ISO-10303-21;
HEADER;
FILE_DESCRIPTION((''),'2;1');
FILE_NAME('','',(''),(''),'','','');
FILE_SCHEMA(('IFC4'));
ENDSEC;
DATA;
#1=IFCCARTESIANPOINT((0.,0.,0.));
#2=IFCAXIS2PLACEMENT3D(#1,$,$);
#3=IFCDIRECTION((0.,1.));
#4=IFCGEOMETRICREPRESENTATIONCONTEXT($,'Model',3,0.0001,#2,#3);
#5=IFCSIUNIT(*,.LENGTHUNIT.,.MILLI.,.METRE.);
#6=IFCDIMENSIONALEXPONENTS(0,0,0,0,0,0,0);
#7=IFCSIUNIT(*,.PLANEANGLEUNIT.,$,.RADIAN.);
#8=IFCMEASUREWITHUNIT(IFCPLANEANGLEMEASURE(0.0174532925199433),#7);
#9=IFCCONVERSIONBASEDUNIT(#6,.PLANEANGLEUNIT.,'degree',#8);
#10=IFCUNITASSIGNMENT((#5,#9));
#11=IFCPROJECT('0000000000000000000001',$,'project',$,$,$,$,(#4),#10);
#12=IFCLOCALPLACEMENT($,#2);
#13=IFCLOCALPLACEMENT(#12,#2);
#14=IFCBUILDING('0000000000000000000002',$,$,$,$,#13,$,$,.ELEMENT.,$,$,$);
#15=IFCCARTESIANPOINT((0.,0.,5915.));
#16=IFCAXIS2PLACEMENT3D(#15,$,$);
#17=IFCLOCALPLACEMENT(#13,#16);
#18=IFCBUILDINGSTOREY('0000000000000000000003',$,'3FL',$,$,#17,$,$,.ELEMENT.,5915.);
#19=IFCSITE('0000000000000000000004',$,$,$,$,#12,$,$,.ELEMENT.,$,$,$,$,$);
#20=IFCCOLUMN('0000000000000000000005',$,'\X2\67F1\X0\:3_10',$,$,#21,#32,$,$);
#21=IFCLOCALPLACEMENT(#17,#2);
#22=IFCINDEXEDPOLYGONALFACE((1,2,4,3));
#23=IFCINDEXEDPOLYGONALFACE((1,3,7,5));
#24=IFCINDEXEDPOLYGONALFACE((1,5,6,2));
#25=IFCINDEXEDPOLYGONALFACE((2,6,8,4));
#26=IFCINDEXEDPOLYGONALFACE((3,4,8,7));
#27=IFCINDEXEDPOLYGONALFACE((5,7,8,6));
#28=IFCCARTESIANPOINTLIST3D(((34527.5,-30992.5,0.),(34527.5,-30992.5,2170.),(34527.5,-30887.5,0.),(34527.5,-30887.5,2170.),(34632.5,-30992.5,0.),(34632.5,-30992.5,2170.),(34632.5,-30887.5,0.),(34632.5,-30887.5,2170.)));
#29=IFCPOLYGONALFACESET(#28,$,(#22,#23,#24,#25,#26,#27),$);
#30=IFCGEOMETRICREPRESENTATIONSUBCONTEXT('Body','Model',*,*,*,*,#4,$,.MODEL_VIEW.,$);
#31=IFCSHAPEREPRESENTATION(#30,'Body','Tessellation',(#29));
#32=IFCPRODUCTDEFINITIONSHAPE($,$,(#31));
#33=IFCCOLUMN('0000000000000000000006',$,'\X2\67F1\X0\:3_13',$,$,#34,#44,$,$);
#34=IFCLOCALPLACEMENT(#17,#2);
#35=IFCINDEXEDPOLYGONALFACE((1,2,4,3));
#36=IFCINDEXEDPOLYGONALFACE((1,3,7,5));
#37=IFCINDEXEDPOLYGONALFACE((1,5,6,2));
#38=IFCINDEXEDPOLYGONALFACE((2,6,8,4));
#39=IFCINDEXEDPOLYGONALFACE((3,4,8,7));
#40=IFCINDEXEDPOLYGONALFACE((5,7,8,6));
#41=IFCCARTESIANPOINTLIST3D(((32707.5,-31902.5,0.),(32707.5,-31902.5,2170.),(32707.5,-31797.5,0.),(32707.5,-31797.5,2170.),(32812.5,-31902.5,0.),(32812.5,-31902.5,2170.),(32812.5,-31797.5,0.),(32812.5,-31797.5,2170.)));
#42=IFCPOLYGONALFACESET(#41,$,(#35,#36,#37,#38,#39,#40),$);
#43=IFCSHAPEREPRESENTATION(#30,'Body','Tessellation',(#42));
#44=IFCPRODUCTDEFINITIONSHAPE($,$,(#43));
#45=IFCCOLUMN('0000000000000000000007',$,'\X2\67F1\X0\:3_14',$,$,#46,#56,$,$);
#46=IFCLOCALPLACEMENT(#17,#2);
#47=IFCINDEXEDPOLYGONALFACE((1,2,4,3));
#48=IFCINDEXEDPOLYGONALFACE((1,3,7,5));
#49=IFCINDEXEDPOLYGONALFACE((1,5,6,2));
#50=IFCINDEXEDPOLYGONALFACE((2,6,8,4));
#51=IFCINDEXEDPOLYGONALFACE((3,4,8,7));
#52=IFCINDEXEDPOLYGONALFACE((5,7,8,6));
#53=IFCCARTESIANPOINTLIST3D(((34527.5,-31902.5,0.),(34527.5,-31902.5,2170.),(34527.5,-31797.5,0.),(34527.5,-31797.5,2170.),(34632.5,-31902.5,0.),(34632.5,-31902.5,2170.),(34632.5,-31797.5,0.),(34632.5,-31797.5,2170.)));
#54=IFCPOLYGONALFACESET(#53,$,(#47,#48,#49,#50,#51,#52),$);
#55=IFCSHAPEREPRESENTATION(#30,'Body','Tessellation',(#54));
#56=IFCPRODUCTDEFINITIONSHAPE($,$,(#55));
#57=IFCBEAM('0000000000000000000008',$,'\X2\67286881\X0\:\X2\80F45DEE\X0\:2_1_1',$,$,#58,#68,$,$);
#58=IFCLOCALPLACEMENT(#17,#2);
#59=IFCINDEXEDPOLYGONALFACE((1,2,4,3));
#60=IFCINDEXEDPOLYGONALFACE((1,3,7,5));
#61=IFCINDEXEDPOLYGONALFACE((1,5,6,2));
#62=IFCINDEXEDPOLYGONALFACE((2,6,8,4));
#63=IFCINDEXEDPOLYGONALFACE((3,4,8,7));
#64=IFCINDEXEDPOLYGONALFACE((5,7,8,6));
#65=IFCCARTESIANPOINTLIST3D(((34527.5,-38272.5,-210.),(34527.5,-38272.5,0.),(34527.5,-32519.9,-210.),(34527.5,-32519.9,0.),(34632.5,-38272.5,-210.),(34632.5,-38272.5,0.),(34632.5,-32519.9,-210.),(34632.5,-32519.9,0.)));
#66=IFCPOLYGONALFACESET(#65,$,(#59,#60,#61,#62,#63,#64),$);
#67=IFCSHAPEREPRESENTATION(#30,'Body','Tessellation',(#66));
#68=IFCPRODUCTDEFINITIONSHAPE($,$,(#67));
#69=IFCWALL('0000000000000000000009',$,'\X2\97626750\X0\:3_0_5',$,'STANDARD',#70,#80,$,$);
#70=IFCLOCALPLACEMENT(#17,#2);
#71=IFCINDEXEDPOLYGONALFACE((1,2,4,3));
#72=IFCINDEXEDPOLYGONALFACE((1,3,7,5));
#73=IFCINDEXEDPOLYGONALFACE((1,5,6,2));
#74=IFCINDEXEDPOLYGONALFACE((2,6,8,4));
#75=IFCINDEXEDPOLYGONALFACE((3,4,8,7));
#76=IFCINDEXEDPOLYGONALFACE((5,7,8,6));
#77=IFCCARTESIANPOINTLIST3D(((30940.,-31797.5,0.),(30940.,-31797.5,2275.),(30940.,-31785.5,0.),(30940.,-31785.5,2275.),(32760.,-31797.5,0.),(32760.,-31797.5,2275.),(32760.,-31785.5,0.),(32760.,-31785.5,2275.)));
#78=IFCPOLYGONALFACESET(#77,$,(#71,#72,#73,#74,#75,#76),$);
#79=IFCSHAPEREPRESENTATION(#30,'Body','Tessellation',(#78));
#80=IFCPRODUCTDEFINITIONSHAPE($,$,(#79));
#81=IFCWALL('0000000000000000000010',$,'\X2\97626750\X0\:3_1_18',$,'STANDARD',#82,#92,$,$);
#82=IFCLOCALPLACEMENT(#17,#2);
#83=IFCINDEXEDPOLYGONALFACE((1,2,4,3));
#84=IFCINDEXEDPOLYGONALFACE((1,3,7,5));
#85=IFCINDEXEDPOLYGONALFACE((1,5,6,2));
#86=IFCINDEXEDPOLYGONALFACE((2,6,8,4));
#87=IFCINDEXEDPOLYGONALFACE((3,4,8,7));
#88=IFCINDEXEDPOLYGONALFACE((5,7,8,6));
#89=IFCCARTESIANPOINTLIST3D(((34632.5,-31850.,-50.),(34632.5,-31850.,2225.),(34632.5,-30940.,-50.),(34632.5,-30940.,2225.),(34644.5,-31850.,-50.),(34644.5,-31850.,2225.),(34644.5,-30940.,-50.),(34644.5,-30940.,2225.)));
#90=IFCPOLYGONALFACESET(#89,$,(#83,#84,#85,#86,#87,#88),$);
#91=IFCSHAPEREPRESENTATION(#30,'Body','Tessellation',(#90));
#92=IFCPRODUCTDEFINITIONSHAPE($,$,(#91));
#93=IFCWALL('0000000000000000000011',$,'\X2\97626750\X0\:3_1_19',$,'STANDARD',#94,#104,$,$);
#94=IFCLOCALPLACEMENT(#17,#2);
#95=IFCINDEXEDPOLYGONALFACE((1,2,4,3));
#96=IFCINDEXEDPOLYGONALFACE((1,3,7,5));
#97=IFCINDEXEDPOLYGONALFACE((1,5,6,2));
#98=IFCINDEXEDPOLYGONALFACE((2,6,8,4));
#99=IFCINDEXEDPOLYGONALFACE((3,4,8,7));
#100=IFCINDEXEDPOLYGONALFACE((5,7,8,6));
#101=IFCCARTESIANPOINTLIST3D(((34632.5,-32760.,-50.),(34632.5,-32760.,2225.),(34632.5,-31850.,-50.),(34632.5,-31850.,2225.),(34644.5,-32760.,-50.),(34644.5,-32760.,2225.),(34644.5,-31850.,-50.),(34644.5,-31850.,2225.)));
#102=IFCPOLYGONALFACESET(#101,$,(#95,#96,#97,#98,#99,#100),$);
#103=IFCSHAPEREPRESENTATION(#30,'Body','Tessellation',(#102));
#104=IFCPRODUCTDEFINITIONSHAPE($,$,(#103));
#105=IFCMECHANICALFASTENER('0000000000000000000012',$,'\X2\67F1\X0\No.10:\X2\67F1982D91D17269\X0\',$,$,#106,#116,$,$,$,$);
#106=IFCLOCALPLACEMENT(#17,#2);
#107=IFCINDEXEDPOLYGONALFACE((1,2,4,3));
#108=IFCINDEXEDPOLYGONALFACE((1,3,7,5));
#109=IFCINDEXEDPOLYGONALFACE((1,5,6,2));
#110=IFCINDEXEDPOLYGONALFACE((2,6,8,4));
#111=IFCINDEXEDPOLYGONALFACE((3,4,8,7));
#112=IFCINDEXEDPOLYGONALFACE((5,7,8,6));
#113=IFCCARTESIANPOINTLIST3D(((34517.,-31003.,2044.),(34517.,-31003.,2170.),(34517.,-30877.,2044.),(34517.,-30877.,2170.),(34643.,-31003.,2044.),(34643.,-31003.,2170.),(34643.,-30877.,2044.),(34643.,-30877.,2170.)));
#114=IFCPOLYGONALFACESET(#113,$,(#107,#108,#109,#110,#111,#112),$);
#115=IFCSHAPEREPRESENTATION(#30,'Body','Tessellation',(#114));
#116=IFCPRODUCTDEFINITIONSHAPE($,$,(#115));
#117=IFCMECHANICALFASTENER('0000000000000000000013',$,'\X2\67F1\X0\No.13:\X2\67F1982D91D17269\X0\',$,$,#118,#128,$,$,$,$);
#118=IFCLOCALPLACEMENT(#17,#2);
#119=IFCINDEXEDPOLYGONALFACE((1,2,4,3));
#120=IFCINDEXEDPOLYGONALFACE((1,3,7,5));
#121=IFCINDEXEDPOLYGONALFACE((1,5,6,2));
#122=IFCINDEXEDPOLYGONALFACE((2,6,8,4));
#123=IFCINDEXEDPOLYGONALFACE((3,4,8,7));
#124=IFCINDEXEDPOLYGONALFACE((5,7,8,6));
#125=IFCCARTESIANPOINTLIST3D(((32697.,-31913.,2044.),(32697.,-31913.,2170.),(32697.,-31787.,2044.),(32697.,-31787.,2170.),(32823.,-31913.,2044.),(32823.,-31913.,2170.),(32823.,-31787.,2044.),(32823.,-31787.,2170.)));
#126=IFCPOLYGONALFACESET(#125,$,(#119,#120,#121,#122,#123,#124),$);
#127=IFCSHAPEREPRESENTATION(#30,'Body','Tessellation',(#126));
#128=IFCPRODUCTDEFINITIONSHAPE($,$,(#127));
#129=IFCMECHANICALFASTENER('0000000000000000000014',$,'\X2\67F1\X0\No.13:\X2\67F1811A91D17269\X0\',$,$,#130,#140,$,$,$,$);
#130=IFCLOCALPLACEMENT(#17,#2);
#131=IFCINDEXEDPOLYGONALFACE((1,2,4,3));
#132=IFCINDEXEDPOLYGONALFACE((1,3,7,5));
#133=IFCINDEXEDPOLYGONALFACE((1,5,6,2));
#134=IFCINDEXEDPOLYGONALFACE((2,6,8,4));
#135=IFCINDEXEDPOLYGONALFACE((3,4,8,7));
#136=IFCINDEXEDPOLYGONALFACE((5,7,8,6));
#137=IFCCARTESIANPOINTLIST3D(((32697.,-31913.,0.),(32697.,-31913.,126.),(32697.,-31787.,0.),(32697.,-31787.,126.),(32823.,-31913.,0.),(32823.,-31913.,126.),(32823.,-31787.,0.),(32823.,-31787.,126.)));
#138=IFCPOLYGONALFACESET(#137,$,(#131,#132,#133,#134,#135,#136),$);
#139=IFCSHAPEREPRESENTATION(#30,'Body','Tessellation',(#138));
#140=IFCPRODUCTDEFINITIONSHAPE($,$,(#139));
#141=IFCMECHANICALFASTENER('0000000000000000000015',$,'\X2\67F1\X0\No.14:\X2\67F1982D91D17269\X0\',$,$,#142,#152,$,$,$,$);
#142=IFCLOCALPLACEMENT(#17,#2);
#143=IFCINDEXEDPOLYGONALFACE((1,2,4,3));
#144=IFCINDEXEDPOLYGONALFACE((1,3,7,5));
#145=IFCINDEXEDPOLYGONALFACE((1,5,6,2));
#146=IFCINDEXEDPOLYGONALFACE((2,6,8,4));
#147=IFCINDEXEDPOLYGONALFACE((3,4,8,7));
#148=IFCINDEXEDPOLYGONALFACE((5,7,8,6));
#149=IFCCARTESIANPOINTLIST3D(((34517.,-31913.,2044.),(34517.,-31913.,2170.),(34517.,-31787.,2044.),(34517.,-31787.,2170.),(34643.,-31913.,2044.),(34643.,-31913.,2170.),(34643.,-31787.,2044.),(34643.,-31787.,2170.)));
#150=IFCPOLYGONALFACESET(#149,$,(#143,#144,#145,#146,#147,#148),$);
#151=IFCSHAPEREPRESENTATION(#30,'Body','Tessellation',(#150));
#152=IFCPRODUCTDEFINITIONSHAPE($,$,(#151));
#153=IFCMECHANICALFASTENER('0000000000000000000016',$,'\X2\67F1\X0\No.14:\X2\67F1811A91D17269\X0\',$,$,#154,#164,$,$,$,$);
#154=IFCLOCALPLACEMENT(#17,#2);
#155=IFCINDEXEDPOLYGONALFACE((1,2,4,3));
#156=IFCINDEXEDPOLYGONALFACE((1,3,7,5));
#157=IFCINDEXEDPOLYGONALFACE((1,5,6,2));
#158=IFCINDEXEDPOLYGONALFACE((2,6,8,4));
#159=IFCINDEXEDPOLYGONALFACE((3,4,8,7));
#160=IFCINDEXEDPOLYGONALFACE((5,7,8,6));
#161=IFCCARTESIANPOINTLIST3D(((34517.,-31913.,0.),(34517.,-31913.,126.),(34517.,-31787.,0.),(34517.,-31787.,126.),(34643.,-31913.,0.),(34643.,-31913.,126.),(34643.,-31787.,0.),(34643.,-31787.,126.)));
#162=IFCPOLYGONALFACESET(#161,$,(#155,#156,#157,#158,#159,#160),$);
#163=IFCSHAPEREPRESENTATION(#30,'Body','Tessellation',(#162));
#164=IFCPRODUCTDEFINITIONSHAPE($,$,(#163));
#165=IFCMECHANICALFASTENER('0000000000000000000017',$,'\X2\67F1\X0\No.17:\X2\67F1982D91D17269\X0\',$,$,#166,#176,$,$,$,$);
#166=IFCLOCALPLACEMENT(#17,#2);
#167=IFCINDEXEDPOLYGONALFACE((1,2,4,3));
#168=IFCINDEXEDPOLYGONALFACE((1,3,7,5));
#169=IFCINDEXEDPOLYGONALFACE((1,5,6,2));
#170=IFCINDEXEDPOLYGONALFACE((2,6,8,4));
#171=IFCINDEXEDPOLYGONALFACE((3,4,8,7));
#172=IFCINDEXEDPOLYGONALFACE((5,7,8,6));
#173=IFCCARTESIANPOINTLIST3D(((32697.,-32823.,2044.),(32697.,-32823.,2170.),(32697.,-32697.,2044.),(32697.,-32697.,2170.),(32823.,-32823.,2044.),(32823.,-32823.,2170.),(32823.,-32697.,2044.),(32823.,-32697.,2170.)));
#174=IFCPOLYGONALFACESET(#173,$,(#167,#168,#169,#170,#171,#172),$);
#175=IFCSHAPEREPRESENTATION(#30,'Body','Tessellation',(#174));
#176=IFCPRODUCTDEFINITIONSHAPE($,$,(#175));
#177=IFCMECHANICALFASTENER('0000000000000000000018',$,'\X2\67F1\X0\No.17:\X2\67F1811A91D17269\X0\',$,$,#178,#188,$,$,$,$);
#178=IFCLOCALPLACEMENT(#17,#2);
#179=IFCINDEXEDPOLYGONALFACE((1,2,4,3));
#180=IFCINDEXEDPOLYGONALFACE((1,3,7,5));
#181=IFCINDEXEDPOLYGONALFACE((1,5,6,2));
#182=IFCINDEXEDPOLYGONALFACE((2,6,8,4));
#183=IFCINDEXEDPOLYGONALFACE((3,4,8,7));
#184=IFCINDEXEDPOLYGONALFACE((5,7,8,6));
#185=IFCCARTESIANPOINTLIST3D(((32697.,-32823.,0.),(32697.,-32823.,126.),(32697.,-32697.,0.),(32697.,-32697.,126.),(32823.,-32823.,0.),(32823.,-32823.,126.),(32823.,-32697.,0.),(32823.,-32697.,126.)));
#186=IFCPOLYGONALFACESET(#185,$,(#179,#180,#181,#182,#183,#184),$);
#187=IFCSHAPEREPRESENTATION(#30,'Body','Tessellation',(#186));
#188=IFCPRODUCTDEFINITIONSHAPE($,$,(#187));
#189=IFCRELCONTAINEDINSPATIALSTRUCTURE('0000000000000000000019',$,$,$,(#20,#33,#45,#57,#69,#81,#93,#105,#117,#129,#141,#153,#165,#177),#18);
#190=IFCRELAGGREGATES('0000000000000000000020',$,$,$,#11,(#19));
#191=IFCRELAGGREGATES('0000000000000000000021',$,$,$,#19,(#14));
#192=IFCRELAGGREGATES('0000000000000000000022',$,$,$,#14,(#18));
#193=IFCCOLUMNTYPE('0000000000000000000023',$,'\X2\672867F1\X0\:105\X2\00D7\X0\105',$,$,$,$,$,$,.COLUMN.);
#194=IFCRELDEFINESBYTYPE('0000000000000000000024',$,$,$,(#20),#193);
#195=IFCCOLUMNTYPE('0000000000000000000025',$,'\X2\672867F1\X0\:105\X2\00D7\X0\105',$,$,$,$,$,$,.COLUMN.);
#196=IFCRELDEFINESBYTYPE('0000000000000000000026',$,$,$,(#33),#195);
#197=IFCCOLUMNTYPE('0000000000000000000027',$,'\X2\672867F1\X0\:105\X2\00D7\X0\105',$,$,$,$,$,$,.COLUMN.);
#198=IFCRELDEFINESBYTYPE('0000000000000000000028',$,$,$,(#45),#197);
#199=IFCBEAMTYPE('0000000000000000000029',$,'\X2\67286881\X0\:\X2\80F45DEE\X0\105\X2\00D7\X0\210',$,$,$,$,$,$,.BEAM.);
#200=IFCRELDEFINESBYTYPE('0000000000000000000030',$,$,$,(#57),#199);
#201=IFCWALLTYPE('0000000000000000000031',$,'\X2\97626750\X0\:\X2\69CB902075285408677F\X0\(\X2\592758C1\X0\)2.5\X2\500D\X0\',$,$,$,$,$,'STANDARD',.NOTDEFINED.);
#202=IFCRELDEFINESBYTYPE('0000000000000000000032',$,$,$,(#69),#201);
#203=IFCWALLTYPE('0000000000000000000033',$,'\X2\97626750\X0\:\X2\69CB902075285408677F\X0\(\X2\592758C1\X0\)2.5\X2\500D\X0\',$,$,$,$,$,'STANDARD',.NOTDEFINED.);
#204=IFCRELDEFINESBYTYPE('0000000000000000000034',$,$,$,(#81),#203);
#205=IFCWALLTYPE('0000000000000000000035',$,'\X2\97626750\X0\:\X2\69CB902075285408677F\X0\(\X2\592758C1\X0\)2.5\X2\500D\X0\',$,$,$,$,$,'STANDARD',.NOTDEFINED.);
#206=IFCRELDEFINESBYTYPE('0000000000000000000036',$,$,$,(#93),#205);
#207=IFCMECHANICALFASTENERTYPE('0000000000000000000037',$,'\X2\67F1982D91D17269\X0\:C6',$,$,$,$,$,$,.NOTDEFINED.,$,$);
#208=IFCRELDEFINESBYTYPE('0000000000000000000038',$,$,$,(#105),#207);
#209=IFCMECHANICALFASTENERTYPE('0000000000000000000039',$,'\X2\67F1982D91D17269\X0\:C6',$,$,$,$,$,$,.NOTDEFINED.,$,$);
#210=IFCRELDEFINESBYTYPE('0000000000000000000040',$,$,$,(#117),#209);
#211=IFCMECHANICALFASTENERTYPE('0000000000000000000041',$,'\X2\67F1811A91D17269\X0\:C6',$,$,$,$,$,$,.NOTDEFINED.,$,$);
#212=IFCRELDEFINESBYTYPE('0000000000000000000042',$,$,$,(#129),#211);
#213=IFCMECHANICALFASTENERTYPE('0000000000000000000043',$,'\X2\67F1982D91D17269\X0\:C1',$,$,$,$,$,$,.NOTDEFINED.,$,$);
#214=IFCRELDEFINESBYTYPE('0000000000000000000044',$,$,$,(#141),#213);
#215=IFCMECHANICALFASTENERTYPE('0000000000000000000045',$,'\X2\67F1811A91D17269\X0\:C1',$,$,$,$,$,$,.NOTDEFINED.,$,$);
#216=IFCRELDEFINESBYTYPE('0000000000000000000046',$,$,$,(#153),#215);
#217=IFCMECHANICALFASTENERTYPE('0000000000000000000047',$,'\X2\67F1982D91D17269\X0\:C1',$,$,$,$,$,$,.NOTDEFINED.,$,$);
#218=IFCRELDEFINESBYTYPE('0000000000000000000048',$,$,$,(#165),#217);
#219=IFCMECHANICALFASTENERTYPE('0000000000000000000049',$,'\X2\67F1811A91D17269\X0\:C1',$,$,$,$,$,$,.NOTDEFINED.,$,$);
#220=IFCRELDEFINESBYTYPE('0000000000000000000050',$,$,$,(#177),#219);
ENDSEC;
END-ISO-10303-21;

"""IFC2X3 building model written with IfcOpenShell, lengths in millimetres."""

from ifc_helpers import new_model, entity, si_unit, converted_unit, direction, frame, origin, origin_with_axes, origin_2d, place, context, subcontext, project, spatial, polyline, rectangle, outline, extrude, type_object, element, save


model = new_model("IFC2X3")

# Units and contexts
model_context = context("Model", 3, precision=0.0001, world=origin(), true_north=direction((0.0, 1.0)))
body_context = subcontext(model_context, "Body", "Model", "MODEL_VIEW")
ifc_project = project(units=[si_unit("LENGTHUNIT", "METRE", prefix="MILLI"), converted_unit("PLANEANGLEUNIT", "degree", entity("IfcPlaneAngleMeasure", 0.0174532925199433), si_unit("PLANEANGLEUNIT", "RADIAN"), dimensions=[0, 0, 0, 0, 0, 0, 0])], contexts=[model_context])

# Site, building, storey
site_placement = place(None, origin())
site = spatial("IfcSite", under=ifc_project, at=site_placement, CompositionType="ELEMENT")
building_placement = place(site_placement, origin())
building = spatial("IfcBuilding", under=site, at=building_placement, CompositionType="ELEMENT")
storey_placement = place(building_placement, frame((0.0, 0.0, 5915.0)))
storey = spatial("IfcBuildingStorey", under=building, at=storey_placement, Name="3FL", CompositionType="ELEMENT", Elevation=5915.0)

# Columns
column_type_1 = type_object("IfcColumnType", Name="木柱:105×105", PredefinedType="COLUMN")
column_1_placement = place(storey_placement, frame((34580.0, -30940.0, 0.0)))
element("IfcColumn", 1, at=column_1_placement, inside=storey, type_object=column_type_1, Name="柱:3_10", context=body_context, shape_type="SweptSolid", body=[
    extrude(rectangle(XDim=105.0, YDim=105.0, at=origin_2d()), origin_with_axes(), (0.0, 0.0, 1.0), 2170.0),
])
column_type_2 = type_object("IfcColumnType", Name="木柱:105×105", PredefinedType="COLUMN")
column_2_placement = place(storey_placement, frame((32760.0, -31850.0, 0.0)))
element("IfcColumn", 2, at=column_2_placement, inside=storey, type_object=column_type_2, Name="柱:3_13", context=body_context, shape_type="SweptSolid", body=[
    extrude(rectangle(XDim=105.0, YDim=105.0, at=origin_2d()), origin_with_axes(), (0.0, 0.0, 1.0), 2170.0),
])
column_type_3 = type_object("IfcColumnType", Name="木柱:105×105", PredefinedType="COLUMN")
column_3_placement = place(storey_placement, frame((34580.0, -31850.0, 0.0)))
element("IfcColumn", 3, at=column_3_placement, inside=storey, type_object=column_type_3, Name="柱:3_14", context=body_context, shape_type="SweptSolid", body=[
    extrude(rectangle(XDim=105.0, YDim=105.0, at=origin_2d()), origin_with_axes(), (0.0, 0.0, 1.0), 2170.0),
])

# Beam
beam_type = type_object("IfcBeamType", Name="木梁:胴差105×210", PredefinedType="BEAM")
beam_placement = place(storey_placement, frame((34580.0, -32519.9, -105.0), z_axis=(0.0, -1.0, 0.0), x_axis=(1.0, 0.0, 0.0)))
element("IfcBeam", 4, at=beam_placement, inside=storey, type_object=beam_type, Name="木梁:胴差:2_1_1", context=body_context, shape_type="SweptSolid", body=[
    extrude(rectangle(XDim=105.0, YDim=210.0, at=origin_2d()), origin_with_axes(), (0.0, 0.0, 1.0), 5752.6),
])

# Walls
wall_type_1 = type_object("IfcWallType", Name="面材:構造用合板(大壁)2.5倍", ElementType="STANDARD", PredefinedType="NOTDEFINED")
wall_1_placement = place(storey_placement, frame((31850.0, -31785.5, 0.0), z_axis=(0.0, -1.0, 0.0), x_axis=(1.0, 0.0, 0.0)))
element("IfcWall", 5, at=wall_1_placement, inside=storey, type_object=wall_type_1, Name="面材:3_0_5", ObjectType="STANDARD", context=body_context, shape_type="SweptSolid", body=[
    extrude(outline(polyline([(910.0, 0.0, 0.0), (-910.0, 0.0, 0.0), (-910.0, 2275.0, 0.0), (910.0, 2275.0, 0.0), (910.0, 0.0, 0.0)])), origin_with_axes(), (0.0, 0.0, 1.0), 12.0),
])
wall_type_2 = type_object("IfcWallType", Name="面材:構造用合板(大壁)2.5倍", ElementType="STANDARD", PredefinedType="NOTDEFINED")
wall_2_placement = place(storey_placement, frame((34644.5, -31395.0, -50.0), z_axis=(-1.0, 0.0, 0.0), x_axis=(0.0, -1.0, 0.0)))
element("IfcWall", 6, at=wall_2_placement, inside=storey, type_object=wall_type_2, Name="面材:3_1_18", ObjectType="STANDARD", context=body_context, shape_type="SweptSolid", body=[
    extrude(outline(polyline([(455.0, 0.0, 0.0), (-455.0, 0.0, 0.0), (-455.0, 2275.0, 0.0), (455.0, 2275.0, 0.0), (455.0, 0.0, 0.0)])), origin_with_axes(), (0.0, 0.0, 1.0), 12.0),
])
wall_type_3 = type_object("IfcWallType", Name="面材:構造用合板(大壁)2.5倍", ElementType="STANDARD", PredefinedType="NOTDEFINED")
wall_3_placement = place(storey_placement, frame((34644.5, -32305.0, -50.0), z_axis=(-1.0, 0.0, 0.0), x_axis=(0.0, -1.0, 0.0)))
element("IfcWall", 7, at=wall_3_placement, inside=storey, type_object=wall_type_3, Name="面材:3_1_19", ObjectType="STANDARD", context=body_context, shape_type="SweptSolid", body=[
    extrude(outline(polyline([(455.0, 0.0, 0.0), (-455.0, 0.0, 0.0), (-455.0, 2275.0, 0.0), (455.0, 2275.0, 0.0), (455.0, 0.0, 0.0)])), origin_with_axes(), (0.0, 0.0, 1.0), 12.0),
])

# Mechanical fasteners
mechanical_fastener_type_1 = type_object("IfcMechanicalFastenerType", Name="柱頭金物:C6")
mechanical_fastener_1_placement = place(storey_placement, frame((34580.0, -30940.0, 2044.0)))
element("IfcMechanicalFastener", 8, at=mechanical_fastener_1_placement, inside=storey, type_object=mechanical_fastener_type_1, Name="柱No.10:柱頭金物", context=body_context, shape_type="SweptSolid", body=[
    extrude(rectangle(XDim=126.0, YDim=126.0, at=origin_2d()), origin_with_axes(), (0.0, 0.0, 1.0), 126.0),
])
mechanical_fastener_type_2 = type_object("IfcMechanicalFastenerType", Name="柱頭金物:C6")
mechanical_fastener_2_placement = place(storey_placement, frame((32760.0, -31850.0, 2044.0)))
element("IfcMechanicalFastener", 9, at=mechanical_fastener_2_placement, inside=storey, type_object=mechanical_fastener_type_2, Name="柱No.13:柱頭金物", context=body_context, shape_type="SweptSolid", body=[
    extrude(rectangle(XDim=126.0, YDim=126.0, at=origin_2d()), origin_with_axes(), (0.0, 0.0, 1.0), 126.0),
])
mechanical_fastener_type_3 = type_object("IfcMechanicalFastenerType", Name="柱脚金物:C6")
mechanical_fastener_3_placement = place(storey_placement, frame((32760.0, -31850.0, 0.0)))
element("IfcMechanicalFastener", 10, at=mechanical_fastener_3_placement, inside=storey, type_object=mechanical_fastener_type_3, Name="柱No.13:柱脚金物", context=body_context, shape_type="SweptSolid", body=[
    extrude(rectangle(XDim=126.0, YDim=126.0, at=origin_2d()), origin_with_axes(), (0.0, 0.0, 1.0), 126.0),
])
mechanical_fastener_type_4 = type_object("IfcMechanicalFastenerType", Name="柱頭金物:C1")
mechanical_fastener_4_placement = place(storey_placement, frame((34580.0, -31850.0, 2044.0)))
element("IfcMechanicalFastener", 11, at=mechanical_fastener_4_placement, inside=storey, type_object=mechanical_fastener_type_4, Name="柱No.14:柱頭金物", context=body_context, shape_type="SweptSolid", body=[
    extrude(rectangle(XDim=126.0, YDim=126.0, at=origin_2d()), origin_with_axes(), (0.0, 0.0, 1.0), 126.0),
])
mechanical_fastener_type_5 = type_object("IfcMechanicalFastenerType", Name="柱脚金物:C1")
mechanical_fastener_5_placement = place(storey_placement, frame((34580.0, -31850.0, 0.0)))
element("IfcMechanicalFastener", 12, at=mechanical_fastener_5_placement, inside=storey, type_object=mechanical_fastener_type_5, Name="柱No.14:柱脚金物", context=body_context, shape_type="SweptSolid", body=[
    extrude(rectangle(XDim=126.0, YDim=126.0, at=origin_2d()), origin_with_axes(), (0.0, 0.0, 1.0), 126.0),
])
mechanical_fastener_type_6 = type_object("IfcMechanicalFastenerType", Name="柱頭金物:C1")
mechanical_fastener_6_placement = place(storey_placement, frame((32760.0, -32760.0, 2044.0)))
element("IfcMechanicalFastener", 13, at=mechanical_fastener_6_placement, inside=storey, type_object=mechanical_fastener_type_6, Name="柱No.17:柱頭金物", context=body_context, shape_type="SweptSolid", body=[
    extrude(rectangle(XDim=126.0, YDim=126.0, at=origin_2d()), origin_with_axes(), (0.0, 0.0, 1.0), 126.0),
])
mechanical_fastener_type_7 = type_object("IfcMechanicalFastenerType", Name="柱脚金物:C1")
mechanical_fastener_7_placement = place(storey_placement, frame((32760.0, -32760.0, 0.0)))
element("IfcMechanicalFastener", 14, at=mechanical_fastener_7_placement, inside=storey, type_object=mechanical_fastener_type_7, Name="柱No.17:柱脚金物", context=body_context, shape_type="SweptSolid", body=[
    extrude(rectangle(XDim=126.0, YDim=126.0, at=origin_2d()), origin_with_axes(), (0.0, 0.0, 1.0), 126.0),
])

save(model, "model.ifc")
